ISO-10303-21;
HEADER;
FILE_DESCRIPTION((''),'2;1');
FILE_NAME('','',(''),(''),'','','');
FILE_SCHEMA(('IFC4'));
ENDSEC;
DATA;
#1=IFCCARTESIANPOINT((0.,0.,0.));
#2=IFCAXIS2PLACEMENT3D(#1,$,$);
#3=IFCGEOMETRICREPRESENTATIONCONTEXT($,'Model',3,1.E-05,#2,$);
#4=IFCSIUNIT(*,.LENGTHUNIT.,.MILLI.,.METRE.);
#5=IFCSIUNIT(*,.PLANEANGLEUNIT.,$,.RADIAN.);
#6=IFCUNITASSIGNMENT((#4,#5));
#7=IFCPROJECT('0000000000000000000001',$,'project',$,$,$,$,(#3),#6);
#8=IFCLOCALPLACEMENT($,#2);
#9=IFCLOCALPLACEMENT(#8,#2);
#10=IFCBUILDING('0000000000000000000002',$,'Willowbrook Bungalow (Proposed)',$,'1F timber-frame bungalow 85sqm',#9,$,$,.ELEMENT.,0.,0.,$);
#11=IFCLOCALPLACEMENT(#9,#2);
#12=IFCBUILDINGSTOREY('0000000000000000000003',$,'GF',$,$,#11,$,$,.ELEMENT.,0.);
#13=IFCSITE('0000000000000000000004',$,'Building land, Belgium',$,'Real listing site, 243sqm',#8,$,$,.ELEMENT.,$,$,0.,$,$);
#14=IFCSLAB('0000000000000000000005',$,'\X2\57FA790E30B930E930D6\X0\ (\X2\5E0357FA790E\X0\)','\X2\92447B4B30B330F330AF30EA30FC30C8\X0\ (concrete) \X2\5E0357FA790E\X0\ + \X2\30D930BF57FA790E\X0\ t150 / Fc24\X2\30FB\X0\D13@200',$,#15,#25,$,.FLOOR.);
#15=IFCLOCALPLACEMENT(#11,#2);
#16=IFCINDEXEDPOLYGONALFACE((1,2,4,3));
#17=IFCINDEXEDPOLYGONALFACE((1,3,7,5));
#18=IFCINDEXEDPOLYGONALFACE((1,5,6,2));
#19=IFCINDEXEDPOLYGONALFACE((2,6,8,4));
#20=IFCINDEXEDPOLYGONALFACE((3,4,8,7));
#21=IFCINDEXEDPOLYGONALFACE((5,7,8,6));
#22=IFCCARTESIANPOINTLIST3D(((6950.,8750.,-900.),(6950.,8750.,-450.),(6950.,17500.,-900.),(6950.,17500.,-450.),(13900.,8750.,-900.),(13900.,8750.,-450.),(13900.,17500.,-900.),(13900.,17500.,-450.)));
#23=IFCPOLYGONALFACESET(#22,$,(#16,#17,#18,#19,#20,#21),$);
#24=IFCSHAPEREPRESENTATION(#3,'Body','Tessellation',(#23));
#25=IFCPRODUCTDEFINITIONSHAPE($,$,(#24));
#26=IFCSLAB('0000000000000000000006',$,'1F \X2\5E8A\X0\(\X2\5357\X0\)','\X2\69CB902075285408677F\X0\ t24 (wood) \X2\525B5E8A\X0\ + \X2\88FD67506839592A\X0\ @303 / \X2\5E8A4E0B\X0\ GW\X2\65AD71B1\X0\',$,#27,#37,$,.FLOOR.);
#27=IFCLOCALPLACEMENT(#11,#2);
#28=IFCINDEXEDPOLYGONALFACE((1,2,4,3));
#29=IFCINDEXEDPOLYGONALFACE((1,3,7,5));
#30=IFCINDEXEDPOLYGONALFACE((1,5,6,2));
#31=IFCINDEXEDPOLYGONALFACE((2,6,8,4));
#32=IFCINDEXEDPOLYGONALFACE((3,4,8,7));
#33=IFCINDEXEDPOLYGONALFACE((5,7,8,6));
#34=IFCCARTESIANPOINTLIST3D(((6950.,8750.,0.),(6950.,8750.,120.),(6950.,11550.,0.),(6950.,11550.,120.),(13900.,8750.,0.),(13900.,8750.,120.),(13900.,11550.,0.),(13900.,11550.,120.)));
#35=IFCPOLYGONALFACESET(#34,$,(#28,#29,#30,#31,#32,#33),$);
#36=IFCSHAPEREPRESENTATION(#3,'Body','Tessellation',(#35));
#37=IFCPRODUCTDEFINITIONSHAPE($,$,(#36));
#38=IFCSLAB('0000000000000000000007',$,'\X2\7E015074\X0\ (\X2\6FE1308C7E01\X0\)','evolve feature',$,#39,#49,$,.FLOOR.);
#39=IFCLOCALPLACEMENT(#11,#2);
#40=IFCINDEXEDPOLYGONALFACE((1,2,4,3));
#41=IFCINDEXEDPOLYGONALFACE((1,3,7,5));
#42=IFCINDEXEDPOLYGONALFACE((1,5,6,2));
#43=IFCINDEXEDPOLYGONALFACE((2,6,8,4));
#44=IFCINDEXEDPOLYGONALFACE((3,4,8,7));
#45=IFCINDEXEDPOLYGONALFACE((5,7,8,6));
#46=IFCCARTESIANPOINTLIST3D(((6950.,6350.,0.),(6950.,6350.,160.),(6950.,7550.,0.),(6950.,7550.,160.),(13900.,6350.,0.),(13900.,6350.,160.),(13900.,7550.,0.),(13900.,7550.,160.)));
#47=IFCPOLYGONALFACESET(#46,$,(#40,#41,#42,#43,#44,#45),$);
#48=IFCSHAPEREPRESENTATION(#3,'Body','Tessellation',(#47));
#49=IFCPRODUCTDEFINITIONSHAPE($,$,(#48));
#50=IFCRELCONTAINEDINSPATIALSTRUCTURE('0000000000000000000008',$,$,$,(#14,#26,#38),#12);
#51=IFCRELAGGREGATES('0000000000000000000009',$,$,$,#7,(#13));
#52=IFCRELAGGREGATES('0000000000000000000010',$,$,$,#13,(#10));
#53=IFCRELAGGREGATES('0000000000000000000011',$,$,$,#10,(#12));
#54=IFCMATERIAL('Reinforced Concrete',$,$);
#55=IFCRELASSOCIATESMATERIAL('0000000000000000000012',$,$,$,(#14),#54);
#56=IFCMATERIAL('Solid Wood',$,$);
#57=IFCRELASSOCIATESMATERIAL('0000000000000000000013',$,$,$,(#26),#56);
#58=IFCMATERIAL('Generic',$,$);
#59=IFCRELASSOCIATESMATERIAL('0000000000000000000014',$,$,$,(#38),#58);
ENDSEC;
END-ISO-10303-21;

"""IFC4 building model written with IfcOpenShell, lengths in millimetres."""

from ifc_helpers import new_model, si_unit, frame, frame_2d, origin, place, context, project, spatial, rectangle, extrude, material, element, save


model = new_model("IFC4")

# Units and contexts
model_context = context("Model", 3, precision=1e-05, world=origin())
ifc_project = project(units=[si_unit("LENGTHUNIT", "METRE", prefix="MILLI"), si_unit("PLANEANGLEUNIT", "RADIAN")], contexts=[model_context])

# Site, building, storey
site_placement = place(None, origin())
site = spatial("IfcSite", under=ifc_project, at=site_placement, Name="Building land, Belgium", ObjectType="Real listing site, 243sqm", CompositionType="ELEMENT", RefElevation=0.0)
building_placement = place(site_placement, origin())
building = spatial("IfcBuilding", under=site, at=building_placement, Name="Willowbrook Bungalow (Proposed)", ObjectType="1F timber-frame bungalow 85sqm", CompositionType="ELEMENT", ElevationOfRefHeight=0.0, ElevationOfTerrain=0.0)
storey_placement = place(building_placement, origin())
storey = spatial("IfcBuildingStorey", under=building, at=storey_placement, Name="GF", CompositionType="ELEMENT", Elevation=0.0)

# Slabs
ifc_material_1 = material(Name="Reinforced Concrete")
slab_1_placement = place(storey_placement, frame((3475.0, 4375.0, -450.0)))
element("IfcSlab", 1, at=slab_1_placement, inside=storey, material=ifc_material_1, Name="基礎スラブ (布基礎)", Description="鉄筋コンクリート (concrete) 布基礎 + ベタ基礎 t150 / Fc24・D13@200", PredefinedType="FLOOR", context=model_context, shape_type="SweptSolid", body=[
    extrude(rectangle(XDim=6950.0, YDim=8750.0, at=frame_2d((3475.0, 4375.0))), frame((3475.0, 4375.0, -450.0)), (0.0, 0.0, 1.0), 450.0),
])
ifc_material_2 = material(Name="Solid Wood")
slab_2_placement = place(storey_placement, frame((3475.0, 4375.0, 0.0)))
element("IfcSlab", 2, at=slab_2_placement, inside=storey, material=ifc_material_2, Name="1F 床(南)", Description="構造用合板 t24 (wood) 剛床 + 製材根太 @303 / 床下 GW断熱", PredefinedType="FLOOR", context=model_context, shape_type="SweptSolid", body=[
    extrude(rectangle(XDim=6950.0, YDim=2800.0, at=frame_2d((3475.0, 1400.0))), frame((3475.0, 4375.0, 0.0)), (0.0, 0.0, 1.0), 120.0),
])
ifc_material_3 = material(Name="Generic")
slab_3_placement = place(storey_placement, frame((3475.0, 3175.0, 0.0)))
element("IfcSlab", 3, at=slab_3_placement, inside=storey, material=ifc_material_3, Name="縁側 (濡れ縁)", Description="evolve feature", PredefinedType="FLOOR", context=model_context, shape_type="SweptSolid", body=[
    extrude(rectangle(XDim=6950.0, YDim=1200.0, at=frame_2d((3475.0, 600.0))), frame((3475.0, 3175.0, 0.0)), (0.0, 0.0, 1.0), 160.0),
])

save(model, "model.ifc")
